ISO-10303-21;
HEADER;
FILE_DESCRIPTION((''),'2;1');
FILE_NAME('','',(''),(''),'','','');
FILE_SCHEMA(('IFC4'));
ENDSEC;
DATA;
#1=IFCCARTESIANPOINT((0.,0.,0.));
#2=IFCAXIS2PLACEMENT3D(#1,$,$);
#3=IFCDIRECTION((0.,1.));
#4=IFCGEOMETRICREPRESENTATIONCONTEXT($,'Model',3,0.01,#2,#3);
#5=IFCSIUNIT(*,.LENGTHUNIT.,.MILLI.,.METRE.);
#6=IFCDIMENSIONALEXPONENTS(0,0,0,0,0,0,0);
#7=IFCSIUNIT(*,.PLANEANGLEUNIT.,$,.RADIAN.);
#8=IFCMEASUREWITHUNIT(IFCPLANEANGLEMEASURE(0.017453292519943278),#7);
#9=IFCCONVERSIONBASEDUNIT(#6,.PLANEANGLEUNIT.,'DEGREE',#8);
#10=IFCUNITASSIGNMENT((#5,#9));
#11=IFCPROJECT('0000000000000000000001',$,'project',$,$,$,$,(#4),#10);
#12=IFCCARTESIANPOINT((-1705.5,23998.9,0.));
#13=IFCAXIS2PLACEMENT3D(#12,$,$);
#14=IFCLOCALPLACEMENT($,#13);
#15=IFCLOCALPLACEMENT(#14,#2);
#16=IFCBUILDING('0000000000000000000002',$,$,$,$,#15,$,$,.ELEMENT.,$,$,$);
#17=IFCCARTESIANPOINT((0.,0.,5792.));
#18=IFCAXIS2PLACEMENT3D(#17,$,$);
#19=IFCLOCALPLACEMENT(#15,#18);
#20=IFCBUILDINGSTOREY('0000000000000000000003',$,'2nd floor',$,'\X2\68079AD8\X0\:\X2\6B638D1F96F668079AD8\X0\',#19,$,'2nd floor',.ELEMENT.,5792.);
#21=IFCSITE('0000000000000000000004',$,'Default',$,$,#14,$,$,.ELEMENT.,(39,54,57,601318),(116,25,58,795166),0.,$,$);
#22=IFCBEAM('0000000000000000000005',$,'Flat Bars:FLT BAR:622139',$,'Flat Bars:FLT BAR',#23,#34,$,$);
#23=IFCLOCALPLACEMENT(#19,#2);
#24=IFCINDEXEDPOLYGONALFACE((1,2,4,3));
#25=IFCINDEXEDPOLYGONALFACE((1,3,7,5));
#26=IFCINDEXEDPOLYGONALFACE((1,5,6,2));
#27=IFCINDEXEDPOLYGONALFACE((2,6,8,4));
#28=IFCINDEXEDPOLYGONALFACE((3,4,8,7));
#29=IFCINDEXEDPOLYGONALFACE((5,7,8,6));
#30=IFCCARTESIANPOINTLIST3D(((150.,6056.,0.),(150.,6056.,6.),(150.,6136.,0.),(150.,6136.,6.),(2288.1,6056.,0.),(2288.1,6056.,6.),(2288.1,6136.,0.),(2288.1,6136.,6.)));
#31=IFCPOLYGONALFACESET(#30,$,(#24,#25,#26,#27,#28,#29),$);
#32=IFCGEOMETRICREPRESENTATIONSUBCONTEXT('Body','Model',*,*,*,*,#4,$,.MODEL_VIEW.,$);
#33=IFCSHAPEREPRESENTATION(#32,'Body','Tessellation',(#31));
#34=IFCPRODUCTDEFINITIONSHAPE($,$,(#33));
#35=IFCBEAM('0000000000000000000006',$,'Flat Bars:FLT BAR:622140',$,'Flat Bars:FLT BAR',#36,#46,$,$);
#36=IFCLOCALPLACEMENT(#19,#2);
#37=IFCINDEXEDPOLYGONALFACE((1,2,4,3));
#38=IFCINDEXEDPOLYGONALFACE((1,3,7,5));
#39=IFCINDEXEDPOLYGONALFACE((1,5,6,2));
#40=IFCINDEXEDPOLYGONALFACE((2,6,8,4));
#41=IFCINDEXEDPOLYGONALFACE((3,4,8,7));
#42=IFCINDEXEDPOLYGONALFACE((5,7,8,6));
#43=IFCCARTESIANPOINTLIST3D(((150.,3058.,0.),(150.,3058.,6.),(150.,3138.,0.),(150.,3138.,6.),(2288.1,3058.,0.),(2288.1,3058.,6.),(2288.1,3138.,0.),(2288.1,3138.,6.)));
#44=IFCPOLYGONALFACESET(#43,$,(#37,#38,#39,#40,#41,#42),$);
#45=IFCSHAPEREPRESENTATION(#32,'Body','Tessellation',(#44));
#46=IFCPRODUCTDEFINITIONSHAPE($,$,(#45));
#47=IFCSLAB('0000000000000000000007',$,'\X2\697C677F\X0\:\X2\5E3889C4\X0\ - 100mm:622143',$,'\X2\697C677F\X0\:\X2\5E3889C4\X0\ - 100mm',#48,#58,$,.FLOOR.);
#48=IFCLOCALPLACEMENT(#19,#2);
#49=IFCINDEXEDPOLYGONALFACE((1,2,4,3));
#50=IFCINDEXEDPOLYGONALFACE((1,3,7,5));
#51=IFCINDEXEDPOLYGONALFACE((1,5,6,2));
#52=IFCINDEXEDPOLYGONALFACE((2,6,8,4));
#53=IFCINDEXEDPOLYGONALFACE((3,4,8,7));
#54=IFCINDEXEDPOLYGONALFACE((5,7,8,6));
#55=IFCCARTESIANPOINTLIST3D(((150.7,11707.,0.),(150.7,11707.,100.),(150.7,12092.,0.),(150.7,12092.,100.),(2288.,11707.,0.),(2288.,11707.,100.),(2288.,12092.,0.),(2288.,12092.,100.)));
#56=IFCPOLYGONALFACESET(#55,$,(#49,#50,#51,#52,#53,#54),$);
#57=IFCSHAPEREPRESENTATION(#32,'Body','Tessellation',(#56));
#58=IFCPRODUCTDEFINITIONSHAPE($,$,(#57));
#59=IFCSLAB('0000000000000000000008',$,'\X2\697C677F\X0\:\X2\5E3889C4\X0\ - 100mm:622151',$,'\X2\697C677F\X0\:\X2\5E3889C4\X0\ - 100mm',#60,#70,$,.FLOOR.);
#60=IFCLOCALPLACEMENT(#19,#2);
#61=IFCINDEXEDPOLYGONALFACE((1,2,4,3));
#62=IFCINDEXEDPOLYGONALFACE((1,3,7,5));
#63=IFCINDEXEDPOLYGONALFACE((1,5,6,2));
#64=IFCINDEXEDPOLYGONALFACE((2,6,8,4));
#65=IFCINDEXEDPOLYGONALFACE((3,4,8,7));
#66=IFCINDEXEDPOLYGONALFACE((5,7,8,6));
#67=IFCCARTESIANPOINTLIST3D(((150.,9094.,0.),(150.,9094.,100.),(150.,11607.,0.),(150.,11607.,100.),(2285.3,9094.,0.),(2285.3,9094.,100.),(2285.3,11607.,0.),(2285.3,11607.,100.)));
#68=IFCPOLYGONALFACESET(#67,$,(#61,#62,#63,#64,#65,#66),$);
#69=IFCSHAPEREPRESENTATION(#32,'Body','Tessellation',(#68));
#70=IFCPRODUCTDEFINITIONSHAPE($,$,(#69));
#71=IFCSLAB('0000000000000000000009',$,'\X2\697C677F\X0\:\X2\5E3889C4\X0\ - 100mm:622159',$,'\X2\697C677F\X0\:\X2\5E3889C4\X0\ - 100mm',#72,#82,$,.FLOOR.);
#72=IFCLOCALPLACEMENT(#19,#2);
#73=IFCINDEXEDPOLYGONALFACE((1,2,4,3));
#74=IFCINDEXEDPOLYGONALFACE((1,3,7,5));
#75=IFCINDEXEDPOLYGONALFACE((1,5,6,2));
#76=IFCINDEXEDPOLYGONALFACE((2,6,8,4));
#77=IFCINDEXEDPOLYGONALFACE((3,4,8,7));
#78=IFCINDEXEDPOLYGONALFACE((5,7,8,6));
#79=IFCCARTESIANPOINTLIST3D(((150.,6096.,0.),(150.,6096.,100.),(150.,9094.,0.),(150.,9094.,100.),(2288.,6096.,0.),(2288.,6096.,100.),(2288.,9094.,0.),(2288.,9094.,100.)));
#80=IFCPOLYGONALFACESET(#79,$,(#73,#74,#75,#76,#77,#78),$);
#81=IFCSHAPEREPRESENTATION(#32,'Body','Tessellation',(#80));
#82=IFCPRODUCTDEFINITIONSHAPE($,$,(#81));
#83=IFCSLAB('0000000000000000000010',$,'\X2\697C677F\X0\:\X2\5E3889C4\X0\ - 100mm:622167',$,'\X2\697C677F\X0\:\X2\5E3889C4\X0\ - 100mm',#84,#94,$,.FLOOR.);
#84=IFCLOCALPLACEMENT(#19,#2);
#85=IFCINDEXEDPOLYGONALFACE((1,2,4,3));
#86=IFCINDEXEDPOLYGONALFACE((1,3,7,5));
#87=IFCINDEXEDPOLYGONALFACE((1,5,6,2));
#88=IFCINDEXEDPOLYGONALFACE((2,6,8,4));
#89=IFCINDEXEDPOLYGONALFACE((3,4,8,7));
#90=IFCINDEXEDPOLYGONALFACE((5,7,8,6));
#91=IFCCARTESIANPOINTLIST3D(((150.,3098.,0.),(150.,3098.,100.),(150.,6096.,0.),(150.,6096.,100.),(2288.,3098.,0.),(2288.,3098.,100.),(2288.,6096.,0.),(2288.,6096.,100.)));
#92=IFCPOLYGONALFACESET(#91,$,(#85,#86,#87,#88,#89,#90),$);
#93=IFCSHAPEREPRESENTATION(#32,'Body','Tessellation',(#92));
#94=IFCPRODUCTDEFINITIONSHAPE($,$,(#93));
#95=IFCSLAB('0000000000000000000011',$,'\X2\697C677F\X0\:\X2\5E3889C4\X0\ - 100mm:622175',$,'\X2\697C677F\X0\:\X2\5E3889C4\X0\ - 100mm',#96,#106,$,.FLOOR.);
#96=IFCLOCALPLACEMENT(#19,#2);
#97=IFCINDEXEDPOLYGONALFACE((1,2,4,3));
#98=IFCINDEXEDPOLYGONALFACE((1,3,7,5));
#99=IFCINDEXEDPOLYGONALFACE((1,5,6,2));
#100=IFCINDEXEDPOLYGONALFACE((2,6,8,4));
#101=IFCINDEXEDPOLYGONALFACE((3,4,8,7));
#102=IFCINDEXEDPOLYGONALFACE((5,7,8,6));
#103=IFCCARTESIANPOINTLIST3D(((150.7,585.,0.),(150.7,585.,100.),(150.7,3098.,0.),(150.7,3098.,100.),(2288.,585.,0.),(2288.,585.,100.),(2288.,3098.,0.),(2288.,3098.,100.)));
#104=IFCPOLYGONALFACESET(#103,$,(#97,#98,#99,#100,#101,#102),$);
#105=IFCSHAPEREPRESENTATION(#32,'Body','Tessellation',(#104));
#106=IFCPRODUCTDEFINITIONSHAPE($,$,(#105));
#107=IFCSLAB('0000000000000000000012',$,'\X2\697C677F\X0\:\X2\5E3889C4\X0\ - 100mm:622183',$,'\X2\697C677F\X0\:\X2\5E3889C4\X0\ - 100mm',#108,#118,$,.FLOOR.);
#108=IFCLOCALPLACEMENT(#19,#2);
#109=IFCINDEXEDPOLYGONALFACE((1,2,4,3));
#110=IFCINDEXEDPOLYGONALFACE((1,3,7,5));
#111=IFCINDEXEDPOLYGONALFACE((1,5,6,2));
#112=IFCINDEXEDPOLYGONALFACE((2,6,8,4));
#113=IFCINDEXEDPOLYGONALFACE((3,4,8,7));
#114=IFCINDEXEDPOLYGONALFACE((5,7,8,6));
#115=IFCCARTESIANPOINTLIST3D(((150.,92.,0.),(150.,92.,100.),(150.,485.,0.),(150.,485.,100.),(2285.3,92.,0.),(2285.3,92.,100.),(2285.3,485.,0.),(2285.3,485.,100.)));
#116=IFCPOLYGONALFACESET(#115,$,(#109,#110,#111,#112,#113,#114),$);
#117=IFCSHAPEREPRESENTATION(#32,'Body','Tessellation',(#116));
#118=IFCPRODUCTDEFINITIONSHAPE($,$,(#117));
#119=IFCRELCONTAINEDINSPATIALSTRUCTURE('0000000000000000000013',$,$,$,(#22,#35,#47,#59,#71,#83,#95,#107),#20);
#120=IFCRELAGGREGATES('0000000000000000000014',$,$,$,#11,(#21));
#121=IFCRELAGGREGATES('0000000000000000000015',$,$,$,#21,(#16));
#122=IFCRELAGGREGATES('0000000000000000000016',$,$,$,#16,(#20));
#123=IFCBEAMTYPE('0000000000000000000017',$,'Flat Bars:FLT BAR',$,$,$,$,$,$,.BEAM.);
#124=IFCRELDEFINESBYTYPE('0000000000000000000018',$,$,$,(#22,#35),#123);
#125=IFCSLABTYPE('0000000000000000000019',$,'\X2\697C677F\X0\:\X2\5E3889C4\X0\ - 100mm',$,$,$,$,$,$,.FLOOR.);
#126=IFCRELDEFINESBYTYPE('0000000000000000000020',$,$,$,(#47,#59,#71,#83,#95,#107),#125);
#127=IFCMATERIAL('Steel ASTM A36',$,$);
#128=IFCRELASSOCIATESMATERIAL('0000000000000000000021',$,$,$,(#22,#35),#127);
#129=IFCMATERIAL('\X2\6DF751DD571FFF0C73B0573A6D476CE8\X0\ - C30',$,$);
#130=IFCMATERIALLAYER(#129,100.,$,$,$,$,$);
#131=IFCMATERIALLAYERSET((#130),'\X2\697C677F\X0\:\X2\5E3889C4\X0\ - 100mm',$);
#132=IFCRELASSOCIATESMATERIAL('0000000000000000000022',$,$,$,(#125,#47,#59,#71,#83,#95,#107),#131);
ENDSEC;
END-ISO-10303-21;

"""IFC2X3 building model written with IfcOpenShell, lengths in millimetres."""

from ifc_helpers import new_model, entity, si_unit, converted_unit, direction, frame, frame_2d, origin, origin_2d_with_axis, place, context, subcontext, project, spatial, rectangle, extrude, material, layer, layer_set, layer_usage, type_object, element, save


model = new_model("IFC2X3")

# Units and contexts
model_context = context("Model", 3, precision=0.01, world=origin(), true_north=direction((0.0, 1.0)))
body_context = subcontext(model_context, "Body", "Model", "MODEL_VIEW")
ifc_project = project(units=[si_unit("LENGTHUNIT", "METRE", prefix="MILLI"), converted_unit("PLANEANGLEUNIT", "DEGREE", entity("IfcPlaneAngleMeasure", 0.017453292519943278), si_unit("PLANEANGLEUNIT", "RADIAN"), dimensions=[0, 0, 0, 0, 0, 0, 0])], contexts=[model_context])

# Site, building, storey
site_placement = place(None, frame((-1705.5, 23998.9, 0.0)))
site = spatial("IfcSite", under=ifc_project, at=site_placement, Name="Default", CompositionType="ELEMENT", RefLatitude=(39, 54, 57, 601318), RefLongitude=(116, 25, 58, 795166), RefElevation=0.0)
building_placement = place(site_placement, origin())
building = spatial("IfcBuilding", under=site, at=building_placement, CompositionType="ELEMENT")
storey_placement = place(building_placement, frame((0.0, 0.0, 5792.0)))
storey = spatial("IfcBuildingStorey", under=building, at=storey_placement, Name="2nd floor", ObjectType="标高:正负零标高", LongName="2nd floor", CompositionType="ELEMENT", Elevation=5792.0)

# Beams
ifc_material_1 = material(Name="Steel ASTM A36")
beam_type_1 = type_object("IfcBeamType", Name="Flat Bars:FLT BAR", PredefinedType="BEAM")
for number, where, name in (
    (1, (150.0, 6096.0, 6.0), "Flat Bars:FLT BAR:622139"),
    (2, (150.0, 3098.0, 6.0), "Flat Bars:FLT BAR:622140"),
):
    element("IfcBeam", number, at=place(storey_placement, frame(where)), inside=storey, type_object=beam_type_1, material=ifc_material_1, Name=name, ObjectType="Flat Bars:FLT BAR", context=body_context, shape_type="SweptSolid", body=[
        extrude(rectangle(XDim=6.0, YDim=80.0, at=origin_2d_with_axis()), frame((0.0, 0.0, -3.0), z_axis=(1.0, 0.0, 0.0), x_axis=(0.0, 0.0, -1.0)), (0.0, 0.0, 1.0), 2138.1),
    ])

# Slabs
ifc_material_2 = material(Name="混凝土，现场浇注 - C30")
ifc_layer_1 = layer(ifc_material_2, 100.0)
ifc_layer_set_1 = layer_set([ifc_layer_1], Name="楼板:常规 - 100mm")
ifc_layer_usage_1 = layer_usage(ifc_layer_set_1, "AXIS3", "POSITIVE", 0.0)
slab_type = type_object("IfcSlabType", Name="楼板:常规 - 100mm", PredefinedType="FLOOR", material=ifc_layer_set_1)
slab_1_placement = place(storey_placement, origin())
element("IfcSlab", 3, at=slab_1_placement, inside=storey, type_object=slab_type, material=ifc_layer_usage_1, Name="楼板:常规 - 100mm:622143", ObjectType="楼板:常规 - 100mm", PredefinedType="FLOOR", context=body_context, shape_type="SweptSolid", body=[
    extrude(rectangle(XDim=385.0, YDim=2137.3, at=origin_2d_with_axis()), frame((1219.3, 11899.5, 100.0), z_axis=(0.0, 0.0, -1.0), x_axis=(0.0, 1.0, 0.0)), (0.0, 0.0, 1.0), 100.0),
])
ifc_layer_usage_2 = layer_usage(ifc_layer_set_1, "AXIS3", "POSITIVE", 0.0)
slab_2_placement = place(storey_placement, origin())
element("IfcSlab", 4, at=slab_2_placement, inside=storey, type_object=slab_type, material=ifc_layer_usage_2, Name="楼板:常规 - 100mm:622151", ObjectType="楼板:常规 - 100mm", PredefinedType="FLOOR", context=body_context, shape_type="SweptSolid", body=[
    extrude(rectangle(XDim=2513.0, YDim=2135.3, at=frame_2d((0.0, 0.0), x_axis=(1.0, 0.0))), frame((1217.6, 10350.5, 100.0), z_axis=(0.0, 0.0, -1.0), x_axis=(0.0, 1.0, 0.0)), (0.0, 0.0, 1.0), 100.0),
])
ifc_layer_usage_3 = layer_usage(ifc_layer_set_1, "AXIS3", "POSITIVE", 0.0)
slab_3_placement = place(storey_placement, origin())
element("IfcSlab", 5, at=slab_3_placement, inside=storey, type_object=slab_type, material=ifc_layer_usage_3, Name="楼板:常规 - 100mm:622159", ObjectType="楼板:常规 - 100mm", PredefinedType="FLOOR", context=body_context, shape_type="SweptSolid", body=[
    extrude(rectangle(XDim=2998.0, YDim=2138.0, at=origin_2d_with_axis()), frame((1219.0, 7595.0, 100.0), z_axis=(0.0, 0.0, -1.0), x_axis=(0.0, 1.0, 0.0)), (0.0, 0.0, 1.0), 100.0),
])
ifc_layer_usage_4 = layer_usage(ifc_layer_set_1, "AXIS3", "POSITIVE", 0.0)
slab_4_placement = place(storey_placement, origin())
element("IfcSlab", 6, at=slab_4_placement, inside=storey, type_object=slab_type, material=ifc_layer_usage_4, Name="楼板:常规 - 100mm:622167", ObjectType="楼板:常规 - 100mm", PredefinedType="FLOOR", context=body_context, shape_type="SweptSolid", body=[
    extrude(rectangle(XDim=2998.0, YDim=2138.0, at=frame_2d((0.0, 0.0), x_axis=(1.0, 0.0))), frame((1219.0, 4597.0, 100.0), z_axis=(0.0, 0.0, -1.0), x_axis=(0.0, 1.0, 0.0)), (0.0, 0.0, 1.0), 100.0),
])
ifc_layer_usage_5 = layer_usage(ifc_layer_set_1, "AXIS3", "POSITIVE", 0.0)
slab_5_placement = place(storey_placement, origin())
element("IfcSlab", 7, at=slab_5_placement, inside=storey, type_object=slab_type, material=ifc_layer_usage_5, Name="楼板:常规 - 100mm:622175", ObjectType="楼板:常规 - 100mm", PredefinedType="FLOOR", context=body_context, shape_type="SweptSolid", body=[
    extrude(rectangle(XDim=2513.0, YDim=2137.3, at=origin_2d_with_axis()), frame((1219.3, 1841.5, 100.0), z_axis=(0.0, 0.0, -1.0), x_axis=(0.0, 1.0, 0.0)), (0.0, 0.0, 1.0), 100.0),
])
ifc_layer_usage_6 = layer_usage(ifc_layer_set_1, "AXIS3", "POSITIVE", 0.0)
slab_6_placement = place(storey_placement, origin())
element("IfcSlab", 8, at=slab_6_placement, inside=storey, type_object=slab_type, material=ifc_layer_usage_6, Name="楼板:常规 - 100mm:622183", ObjectType="楼板:常规 - 100mm", PredefinedType="FLOOR", context=body_context, shape_type="SweptSolid", body=[
    extrude(rectangle(XDim=393.0, YDim=2135.3, at=frame_2d((0.0, 0.0), x_axis=(1.0, 0.0))), frame((1217.7, 288.5, 100.0), z_axis=(0.0, 0.0, -1.0), x_axis=(0.0, 1.0, 0.0)), (0.0, 0.0, 1.0), 100.0),
])

save(model, "model.ifc")
